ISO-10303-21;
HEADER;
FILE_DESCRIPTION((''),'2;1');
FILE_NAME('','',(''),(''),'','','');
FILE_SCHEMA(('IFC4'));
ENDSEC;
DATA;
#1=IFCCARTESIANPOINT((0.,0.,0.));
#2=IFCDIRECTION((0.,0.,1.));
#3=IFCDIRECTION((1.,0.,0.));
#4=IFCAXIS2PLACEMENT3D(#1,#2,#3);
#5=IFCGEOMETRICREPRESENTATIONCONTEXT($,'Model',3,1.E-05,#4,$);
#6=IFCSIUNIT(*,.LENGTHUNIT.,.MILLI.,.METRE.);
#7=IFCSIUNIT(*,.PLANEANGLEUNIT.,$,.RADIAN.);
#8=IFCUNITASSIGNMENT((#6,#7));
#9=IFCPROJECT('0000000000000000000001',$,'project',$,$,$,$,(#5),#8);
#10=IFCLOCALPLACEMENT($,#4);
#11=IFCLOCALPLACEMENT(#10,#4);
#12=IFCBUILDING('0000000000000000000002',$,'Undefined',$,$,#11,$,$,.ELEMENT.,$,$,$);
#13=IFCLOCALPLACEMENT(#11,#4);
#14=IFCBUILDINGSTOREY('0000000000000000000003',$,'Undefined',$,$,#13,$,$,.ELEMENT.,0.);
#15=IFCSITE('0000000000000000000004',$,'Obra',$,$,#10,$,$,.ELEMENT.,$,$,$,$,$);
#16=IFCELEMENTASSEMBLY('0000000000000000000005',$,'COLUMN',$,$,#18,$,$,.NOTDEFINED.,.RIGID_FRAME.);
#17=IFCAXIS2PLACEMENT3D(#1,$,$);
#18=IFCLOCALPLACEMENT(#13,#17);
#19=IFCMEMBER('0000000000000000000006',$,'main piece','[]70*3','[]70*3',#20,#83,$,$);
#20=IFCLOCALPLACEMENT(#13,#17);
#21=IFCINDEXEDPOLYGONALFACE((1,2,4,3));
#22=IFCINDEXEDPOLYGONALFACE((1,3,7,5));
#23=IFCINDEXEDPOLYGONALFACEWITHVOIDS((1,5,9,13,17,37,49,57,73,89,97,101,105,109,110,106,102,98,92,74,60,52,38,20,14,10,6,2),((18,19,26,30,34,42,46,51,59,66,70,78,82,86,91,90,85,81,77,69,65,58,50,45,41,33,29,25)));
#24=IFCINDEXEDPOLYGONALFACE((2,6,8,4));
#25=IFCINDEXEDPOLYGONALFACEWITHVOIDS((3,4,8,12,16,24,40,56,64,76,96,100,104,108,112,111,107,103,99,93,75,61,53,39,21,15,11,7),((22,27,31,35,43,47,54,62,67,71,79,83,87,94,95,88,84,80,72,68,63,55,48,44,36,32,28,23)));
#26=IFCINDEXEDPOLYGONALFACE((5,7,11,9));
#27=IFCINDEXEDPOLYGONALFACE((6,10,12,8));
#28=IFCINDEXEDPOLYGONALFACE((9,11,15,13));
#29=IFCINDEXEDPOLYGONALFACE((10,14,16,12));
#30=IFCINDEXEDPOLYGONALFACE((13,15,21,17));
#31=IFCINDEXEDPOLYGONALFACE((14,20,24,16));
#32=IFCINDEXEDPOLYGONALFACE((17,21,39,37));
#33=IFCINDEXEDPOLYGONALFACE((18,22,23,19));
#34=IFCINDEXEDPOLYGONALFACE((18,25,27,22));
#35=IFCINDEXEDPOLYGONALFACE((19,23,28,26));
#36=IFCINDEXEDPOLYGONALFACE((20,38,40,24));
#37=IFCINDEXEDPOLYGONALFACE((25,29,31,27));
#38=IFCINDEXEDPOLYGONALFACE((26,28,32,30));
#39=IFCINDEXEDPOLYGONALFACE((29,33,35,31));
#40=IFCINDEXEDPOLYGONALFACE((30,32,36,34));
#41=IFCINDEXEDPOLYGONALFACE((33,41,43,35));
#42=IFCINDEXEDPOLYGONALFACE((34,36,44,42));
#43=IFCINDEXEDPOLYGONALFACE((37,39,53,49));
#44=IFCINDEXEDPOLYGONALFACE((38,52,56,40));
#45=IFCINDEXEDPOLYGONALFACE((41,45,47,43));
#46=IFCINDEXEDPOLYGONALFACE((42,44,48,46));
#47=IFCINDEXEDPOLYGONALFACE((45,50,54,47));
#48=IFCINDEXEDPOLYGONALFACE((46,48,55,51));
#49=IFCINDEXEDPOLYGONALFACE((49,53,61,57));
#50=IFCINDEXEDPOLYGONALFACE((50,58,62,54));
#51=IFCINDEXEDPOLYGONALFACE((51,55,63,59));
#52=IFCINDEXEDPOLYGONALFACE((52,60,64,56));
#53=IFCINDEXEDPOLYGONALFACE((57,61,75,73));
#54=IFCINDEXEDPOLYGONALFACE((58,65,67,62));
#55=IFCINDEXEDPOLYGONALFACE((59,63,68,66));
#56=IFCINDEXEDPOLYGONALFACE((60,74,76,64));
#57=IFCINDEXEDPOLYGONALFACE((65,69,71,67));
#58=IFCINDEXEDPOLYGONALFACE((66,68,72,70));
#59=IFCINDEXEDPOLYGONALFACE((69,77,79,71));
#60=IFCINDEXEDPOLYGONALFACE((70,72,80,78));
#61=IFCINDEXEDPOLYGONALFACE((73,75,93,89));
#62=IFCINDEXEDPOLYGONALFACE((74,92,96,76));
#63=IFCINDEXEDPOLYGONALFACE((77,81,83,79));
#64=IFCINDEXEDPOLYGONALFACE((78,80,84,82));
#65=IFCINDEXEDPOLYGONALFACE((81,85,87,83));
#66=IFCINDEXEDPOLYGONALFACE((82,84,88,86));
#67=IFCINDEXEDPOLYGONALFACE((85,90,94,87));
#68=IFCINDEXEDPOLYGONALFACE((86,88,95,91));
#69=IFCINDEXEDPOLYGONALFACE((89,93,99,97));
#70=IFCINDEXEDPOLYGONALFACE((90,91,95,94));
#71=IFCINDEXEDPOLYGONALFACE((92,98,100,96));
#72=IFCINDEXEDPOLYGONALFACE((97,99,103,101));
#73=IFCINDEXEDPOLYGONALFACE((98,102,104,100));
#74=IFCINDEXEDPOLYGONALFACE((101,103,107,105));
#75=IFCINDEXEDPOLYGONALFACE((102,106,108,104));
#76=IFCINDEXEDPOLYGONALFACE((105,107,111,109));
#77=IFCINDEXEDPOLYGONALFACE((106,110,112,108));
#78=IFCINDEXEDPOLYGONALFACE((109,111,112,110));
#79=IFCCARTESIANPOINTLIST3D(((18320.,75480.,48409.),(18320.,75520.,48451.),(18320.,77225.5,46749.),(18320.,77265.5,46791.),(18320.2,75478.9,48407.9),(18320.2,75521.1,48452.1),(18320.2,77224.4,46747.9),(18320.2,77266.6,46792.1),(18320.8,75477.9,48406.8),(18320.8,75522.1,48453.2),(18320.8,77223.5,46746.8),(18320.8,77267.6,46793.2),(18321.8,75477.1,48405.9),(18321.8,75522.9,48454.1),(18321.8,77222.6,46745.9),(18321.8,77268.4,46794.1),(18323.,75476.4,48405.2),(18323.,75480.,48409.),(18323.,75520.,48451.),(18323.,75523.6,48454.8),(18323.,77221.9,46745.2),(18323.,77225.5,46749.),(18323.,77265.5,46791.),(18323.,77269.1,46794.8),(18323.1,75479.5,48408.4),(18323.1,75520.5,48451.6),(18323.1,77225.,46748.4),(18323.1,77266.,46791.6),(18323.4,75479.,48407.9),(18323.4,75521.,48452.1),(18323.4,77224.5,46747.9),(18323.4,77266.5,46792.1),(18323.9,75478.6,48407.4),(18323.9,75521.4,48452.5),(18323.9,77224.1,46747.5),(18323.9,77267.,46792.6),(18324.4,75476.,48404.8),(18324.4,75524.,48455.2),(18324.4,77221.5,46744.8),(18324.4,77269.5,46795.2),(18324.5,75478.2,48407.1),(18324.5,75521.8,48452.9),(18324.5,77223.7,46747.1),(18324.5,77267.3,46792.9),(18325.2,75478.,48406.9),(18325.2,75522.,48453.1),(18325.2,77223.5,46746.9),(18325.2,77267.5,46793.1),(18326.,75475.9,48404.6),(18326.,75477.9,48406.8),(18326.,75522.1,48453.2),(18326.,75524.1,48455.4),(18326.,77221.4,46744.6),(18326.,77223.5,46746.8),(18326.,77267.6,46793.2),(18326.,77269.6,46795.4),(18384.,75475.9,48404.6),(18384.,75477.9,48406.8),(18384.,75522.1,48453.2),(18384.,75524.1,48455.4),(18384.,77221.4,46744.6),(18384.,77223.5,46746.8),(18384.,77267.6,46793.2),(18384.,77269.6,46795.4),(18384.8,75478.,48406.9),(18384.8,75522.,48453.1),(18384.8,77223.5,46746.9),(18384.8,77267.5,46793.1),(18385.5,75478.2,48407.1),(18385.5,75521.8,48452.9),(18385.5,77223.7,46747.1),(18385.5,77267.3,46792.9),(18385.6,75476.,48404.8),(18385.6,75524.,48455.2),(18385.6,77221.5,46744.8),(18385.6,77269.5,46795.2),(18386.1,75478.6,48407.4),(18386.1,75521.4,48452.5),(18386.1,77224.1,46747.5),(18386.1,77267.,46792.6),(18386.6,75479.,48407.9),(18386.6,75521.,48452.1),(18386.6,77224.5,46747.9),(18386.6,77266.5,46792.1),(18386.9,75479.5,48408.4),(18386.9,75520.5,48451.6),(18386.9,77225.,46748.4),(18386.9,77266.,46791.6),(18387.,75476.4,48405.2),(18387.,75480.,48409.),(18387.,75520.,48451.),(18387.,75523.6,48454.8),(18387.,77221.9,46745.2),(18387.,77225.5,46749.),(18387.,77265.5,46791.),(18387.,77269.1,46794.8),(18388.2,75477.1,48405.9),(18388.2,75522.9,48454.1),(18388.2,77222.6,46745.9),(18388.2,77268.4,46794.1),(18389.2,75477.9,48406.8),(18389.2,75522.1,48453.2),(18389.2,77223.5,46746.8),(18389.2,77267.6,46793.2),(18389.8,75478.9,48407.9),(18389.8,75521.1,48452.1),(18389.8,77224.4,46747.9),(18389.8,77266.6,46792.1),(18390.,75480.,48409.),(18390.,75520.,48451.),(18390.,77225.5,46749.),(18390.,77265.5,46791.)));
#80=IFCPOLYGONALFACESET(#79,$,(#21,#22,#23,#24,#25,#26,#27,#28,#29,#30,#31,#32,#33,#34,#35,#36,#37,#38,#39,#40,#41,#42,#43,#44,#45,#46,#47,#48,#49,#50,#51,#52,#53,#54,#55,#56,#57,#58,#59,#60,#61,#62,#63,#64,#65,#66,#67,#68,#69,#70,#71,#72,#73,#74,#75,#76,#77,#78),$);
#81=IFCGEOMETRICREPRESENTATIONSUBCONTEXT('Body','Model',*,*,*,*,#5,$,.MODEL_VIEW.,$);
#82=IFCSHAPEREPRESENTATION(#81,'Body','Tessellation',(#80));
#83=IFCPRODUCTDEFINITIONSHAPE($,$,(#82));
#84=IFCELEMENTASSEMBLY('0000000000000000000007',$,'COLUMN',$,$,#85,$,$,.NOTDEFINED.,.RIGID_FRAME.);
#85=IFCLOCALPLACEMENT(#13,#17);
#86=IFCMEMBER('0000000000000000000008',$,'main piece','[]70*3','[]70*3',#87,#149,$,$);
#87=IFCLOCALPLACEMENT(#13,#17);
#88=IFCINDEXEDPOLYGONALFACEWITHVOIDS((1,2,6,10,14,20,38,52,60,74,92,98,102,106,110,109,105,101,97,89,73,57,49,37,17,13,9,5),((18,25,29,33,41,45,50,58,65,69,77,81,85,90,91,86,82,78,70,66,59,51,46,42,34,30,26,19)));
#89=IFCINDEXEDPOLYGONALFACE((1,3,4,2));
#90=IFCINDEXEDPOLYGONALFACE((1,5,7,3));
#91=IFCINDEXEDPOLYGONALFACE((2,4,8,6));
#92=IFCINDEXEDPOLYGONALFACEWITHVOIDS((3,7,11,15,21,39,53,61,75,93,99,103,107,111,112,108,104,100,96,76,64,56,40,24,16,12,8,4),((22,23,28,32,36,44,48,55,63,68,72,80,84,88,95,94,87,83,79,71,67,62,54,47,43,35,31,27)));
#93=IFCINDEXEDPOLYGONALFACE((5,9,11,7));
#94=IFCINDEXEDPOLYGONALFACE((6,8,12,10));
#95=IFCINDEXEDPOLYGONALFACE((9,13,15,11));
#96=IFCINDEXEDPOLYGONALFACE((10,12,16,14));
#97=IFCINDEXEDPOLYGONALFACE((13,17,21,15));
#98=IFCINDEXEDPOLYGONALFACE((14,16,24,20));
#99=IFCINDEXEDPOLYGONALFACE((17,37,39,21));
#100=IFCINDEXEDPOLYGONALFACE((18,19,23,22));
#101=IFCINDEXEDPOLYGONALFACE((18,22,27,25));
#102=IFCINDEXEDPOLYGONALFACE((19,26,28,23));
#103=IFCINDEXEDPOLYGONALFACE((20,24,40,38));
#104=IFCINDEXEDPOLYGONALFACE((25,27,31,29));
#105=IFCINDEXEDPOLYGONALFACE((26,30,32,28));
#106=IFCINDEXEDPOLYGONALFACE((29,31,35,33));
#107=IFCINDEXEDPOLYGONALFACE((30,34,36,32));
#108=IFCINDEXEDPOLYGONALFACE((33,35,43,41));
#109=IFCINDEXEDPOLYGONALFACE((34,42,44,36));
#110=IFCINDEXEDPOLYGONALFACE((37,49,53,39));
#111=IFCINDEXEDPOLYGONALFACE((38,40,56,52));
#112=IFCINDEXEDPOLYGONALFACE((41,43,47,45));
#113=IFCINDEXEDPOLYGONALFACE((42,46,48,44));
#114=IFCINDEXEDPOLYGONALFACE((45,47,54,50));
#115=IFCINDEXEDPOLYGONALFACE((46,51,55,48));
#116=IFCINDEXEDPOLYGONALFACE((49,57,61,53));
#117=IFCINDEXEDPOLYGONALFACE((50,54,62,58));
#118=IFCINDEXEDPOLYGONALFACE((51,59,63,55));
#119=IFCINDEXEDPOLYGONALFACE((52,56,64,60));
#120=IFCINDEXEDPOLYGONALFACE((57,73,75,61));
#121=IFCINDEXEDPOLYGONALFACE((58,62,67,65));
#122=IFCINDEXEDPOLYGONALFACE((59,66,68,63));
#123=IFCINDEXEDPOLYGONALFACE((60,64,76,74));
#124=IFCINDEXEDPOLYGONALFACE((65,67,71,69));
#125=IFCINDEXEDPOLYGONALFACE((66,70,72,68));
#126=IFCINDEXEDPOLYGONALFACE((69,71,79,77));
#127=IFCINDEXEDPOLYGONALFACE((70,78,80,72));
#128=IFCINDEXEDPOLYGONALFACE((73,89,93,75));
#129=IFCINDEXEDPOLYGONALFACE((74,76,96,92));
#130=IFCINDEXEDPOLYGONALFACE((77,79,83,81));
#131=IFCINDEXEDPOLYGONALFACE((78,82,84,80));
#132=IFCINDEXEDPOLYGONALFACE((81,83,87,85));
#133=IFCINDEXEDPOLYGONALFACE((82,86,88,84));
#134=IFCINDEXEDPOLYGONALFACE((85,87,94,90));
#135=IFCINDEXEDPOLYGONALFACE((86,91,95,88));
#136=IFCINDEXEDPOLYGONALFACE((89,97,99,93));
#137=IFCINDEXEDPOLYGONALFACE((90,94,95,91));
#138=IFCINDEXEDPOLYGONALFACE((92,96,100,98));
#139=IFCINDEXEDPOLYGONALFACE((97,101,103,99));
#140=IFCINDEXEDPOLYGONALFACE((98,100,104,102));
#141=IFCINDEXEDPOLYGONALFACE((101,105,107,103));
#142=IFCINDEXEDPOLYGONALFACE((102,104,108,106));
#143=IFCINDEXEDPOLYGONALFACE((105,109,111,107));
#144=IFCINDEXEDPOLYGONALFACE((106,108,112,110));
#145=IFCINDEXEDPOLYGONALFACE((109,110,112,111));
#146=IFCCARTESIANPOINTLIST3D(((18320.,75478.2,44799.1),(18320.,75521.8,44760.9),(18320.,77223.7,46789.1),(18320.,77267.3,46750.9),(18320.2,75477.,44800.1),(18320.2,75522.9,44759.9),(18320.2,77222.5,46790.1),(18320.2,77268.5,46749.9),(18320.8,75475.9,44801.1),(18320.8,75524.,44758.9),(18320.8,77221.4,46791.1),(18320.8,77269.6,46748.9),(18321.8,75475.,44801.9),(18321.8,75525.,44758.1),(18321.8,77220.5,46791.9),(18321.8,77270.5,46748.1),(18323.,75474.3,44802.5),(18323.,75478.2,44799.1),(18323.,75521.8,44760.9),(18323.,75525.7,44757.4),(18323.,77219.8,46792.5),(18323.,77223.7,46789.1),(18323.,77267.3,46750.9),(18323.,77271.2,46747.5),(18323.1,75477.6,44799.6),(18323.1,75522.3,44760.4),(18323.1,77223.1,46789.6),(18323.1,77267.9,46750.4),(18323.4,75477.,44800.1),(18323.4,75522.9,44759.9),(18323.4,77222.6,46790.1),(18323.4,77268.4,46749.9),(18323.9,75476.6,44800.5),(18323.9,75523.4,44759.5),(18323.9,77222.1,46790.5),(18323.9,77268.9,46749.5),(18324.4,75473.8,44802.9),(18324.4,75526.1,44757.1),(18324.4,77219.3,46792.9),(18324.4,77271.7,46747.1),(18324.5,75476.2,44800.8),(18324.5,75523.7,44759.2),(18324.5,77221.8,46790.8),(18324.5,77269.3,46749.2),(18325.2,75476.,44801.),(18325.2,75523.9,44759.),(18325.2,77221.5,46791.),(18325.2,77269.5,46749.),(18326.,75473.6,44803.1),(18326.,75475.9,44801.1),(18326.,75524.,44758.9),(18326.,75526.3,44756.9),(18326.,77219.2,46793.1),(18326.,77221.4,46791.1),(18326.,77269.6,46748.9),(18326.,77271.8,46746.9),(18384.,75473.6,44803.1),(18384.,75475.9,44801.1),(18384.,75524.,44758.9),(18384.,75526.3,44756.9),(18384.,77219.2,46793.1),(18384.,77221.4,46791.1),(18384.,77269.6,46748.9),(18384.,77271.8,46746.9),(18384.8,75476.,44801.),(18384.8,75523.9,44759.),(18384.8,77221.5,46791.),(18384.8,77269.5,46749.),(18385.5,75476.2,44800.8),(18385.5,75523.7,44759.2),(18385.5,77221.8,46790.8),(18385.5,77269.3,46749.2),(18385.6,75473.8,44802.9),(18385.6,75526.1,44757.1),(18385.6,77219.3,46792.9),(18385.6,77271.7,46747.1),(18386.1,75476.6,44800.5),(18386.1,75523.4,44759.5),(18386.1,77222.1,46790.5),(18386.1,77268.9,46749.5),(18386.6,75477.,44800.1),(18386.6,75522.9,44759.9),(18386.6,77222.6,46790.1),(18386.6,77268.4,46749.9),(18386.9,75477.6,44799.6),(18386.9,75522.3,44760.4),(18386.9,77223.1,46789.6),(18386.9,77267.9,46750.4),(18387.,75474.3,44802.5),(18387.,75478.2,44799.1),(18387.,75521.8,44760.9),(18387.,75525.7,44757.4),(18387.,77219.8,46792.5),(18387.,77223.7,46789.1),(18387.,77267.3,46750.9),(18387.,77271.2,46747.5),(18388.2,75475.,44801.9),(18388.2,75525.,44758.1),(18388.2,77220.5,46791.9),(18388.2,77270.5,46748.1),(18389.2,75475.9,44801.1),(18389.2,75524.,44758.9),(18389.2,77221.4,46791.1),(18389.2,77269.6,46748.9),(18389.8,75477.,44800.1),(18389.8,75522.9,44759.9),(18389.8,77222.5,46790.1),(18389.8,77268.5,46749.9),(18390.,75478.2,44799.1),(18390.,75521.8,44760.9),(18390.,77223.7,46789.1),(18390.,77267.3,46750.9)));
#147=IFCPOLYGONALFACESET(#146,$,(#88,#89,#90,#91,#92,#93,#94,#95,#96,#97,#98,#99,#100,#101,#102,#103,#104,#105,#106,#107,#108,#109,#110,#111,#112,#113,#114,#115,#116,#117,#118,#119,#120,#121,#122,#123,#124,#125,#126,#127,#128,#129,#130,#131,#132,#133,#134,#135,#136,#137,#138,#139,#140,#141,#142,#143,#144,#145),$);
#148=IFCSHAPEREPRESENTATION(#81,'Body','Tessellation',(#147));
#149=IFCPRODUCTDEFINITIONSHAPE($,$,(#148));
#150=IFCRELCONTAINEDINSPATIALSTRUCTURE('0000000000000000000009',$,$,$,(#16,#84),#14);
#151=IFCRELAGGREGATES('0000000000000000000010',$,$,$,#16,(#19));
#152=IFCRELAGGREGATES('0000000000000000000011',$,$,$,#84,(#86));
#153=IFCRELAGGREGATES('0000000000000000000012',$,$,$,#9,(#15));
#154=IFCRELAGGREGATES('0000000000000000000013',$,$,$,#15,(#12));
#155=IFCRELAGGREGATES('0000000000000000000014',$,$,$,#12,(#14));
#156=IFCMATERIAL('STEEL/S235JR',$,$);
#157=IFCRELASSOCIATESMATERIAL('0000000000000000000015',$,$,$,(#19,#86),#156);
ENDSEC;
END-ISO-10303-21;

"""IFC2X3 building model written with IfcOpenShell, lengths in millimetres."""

from ifc_helpers import new_model, si_unit, frame, origin_with_axes, origin_2d_with_axis, place, context, subcontext, project, spatial, hollow_rectangle, extrude, material, element, aggregate, save


model = new_model("IFC2X3")

# Units and contexts
model_context = context("Model", 3, precision=1e-05, world=origin_with_axes())
body_context = subcontext(model_context, "Body", "Model", "MODEL_VIEW")
ifc_project = project(units=[si_unit("LENGTHUNIT", "METRE", prefix="MILLI"), si_unit("PLANEANGLEUNIT", "RADIAN")], contexts=[model_context])

# Site, building, storey
site_placement = place(None, origin_with_axes())
site = spatial("IfcSite", under=ifc_project, at=site_placement, Name="Obra", CompositionType="ELEMENT")
building_placement = place(site_placement, origin_with_axes())
building = spatial("IfcBuilding", under=site, at=building_placement, Name="Undefined", CompositionType="ELEMENT")
storey_placement = place(building_placement, origin_with_axes())
storey = spatial("IfcBuildingStorey", under=building, at=storey_placement, Name="Undefined", CompositionType="ELEMENT", Elevation=0.0)

# Shared definitions
ifc_material = material(Name="STEEL/S235JR")

# Element assemblies, members
assembly_1_placement = place(storey_placement, origin_with_axes())
assembly_1 = element("IfcElementAssembly", 1, at=assembly_1_placement, inside=storey, Name="COLUMN", AssemblyPlace="NOTDEFINED", PredefinedType="RIGID_FRAME")
member_1_placement = place(assembly_1_placement, frame((18355.0, 77245.5, 46770.0), z_axis=(1.0, 0.0, 0.0), x_axis=(0.0, -0.724633, 0.689135)))
member_1 = element("IfcMember", 2, at=member_1_placement, material=ifc_material, Name="main piece", Description="[]70*3", ObjectType="[]70*3", context=body_context, shape_type="SweptSolid", body=[
    extrude(hollow_rectangle(XDim=70.0, YDim=70.0, WallThickness=3.0, InnerFilletRadius=3.0, OuterFilletRadius=6.0, at=origin_2d_with_axis()), frame((2408.8, 0.0, 0.0), z_axis=(-1.0, 0.0, 0.0), x_axis=(0.0, -1.0, 0.0)), (0.0, 0.0, 1.0), 2408.8),
])
aggregate(assembly_1, [member_1])
assembly_2_placement = place(storey_placement, origin_with_axes())
assembly_2 = element("IfcElementAssembly", 3, at=assembly_2_placement, inside=storey, Name="COLUMN", AssemblyPlace="NOTDEFINED", PredefinedType="RIGID_FRAME")
member_2_placement = place(assembly_2_placement, frame((18355.0, 75500.0, 44780.0), z_axis=(-1.0, 0.0, 0.0), x_axis=(0.0, 0.659423, 0.751772)))
member_2 = element("IfcMember", 4, at=member_2_placement, material=ifc_material, Name="main piece", Description="[]70*3", ObjectType="[]70*3", context=body_context, shape_type="SweptSolid", body=[
    extrude(hollow_rectangle(XDim=70.0, YDim=70.0, WallThickness=3.0, InnerFilletRadius=3.0, OuterFilletRadius=6.0, at=origin_2d_with_axis()), frame((2647.1, 0.0, 0.0), z_axis=(-1.0, 0.0, 0.0), x_axis=(0.0, -1.0, 0.0)), (0.0, 0.0, 1.0), 2647.1),
])
aggregate(assembly_2, [member_2])

save(model, "model.ifc")
